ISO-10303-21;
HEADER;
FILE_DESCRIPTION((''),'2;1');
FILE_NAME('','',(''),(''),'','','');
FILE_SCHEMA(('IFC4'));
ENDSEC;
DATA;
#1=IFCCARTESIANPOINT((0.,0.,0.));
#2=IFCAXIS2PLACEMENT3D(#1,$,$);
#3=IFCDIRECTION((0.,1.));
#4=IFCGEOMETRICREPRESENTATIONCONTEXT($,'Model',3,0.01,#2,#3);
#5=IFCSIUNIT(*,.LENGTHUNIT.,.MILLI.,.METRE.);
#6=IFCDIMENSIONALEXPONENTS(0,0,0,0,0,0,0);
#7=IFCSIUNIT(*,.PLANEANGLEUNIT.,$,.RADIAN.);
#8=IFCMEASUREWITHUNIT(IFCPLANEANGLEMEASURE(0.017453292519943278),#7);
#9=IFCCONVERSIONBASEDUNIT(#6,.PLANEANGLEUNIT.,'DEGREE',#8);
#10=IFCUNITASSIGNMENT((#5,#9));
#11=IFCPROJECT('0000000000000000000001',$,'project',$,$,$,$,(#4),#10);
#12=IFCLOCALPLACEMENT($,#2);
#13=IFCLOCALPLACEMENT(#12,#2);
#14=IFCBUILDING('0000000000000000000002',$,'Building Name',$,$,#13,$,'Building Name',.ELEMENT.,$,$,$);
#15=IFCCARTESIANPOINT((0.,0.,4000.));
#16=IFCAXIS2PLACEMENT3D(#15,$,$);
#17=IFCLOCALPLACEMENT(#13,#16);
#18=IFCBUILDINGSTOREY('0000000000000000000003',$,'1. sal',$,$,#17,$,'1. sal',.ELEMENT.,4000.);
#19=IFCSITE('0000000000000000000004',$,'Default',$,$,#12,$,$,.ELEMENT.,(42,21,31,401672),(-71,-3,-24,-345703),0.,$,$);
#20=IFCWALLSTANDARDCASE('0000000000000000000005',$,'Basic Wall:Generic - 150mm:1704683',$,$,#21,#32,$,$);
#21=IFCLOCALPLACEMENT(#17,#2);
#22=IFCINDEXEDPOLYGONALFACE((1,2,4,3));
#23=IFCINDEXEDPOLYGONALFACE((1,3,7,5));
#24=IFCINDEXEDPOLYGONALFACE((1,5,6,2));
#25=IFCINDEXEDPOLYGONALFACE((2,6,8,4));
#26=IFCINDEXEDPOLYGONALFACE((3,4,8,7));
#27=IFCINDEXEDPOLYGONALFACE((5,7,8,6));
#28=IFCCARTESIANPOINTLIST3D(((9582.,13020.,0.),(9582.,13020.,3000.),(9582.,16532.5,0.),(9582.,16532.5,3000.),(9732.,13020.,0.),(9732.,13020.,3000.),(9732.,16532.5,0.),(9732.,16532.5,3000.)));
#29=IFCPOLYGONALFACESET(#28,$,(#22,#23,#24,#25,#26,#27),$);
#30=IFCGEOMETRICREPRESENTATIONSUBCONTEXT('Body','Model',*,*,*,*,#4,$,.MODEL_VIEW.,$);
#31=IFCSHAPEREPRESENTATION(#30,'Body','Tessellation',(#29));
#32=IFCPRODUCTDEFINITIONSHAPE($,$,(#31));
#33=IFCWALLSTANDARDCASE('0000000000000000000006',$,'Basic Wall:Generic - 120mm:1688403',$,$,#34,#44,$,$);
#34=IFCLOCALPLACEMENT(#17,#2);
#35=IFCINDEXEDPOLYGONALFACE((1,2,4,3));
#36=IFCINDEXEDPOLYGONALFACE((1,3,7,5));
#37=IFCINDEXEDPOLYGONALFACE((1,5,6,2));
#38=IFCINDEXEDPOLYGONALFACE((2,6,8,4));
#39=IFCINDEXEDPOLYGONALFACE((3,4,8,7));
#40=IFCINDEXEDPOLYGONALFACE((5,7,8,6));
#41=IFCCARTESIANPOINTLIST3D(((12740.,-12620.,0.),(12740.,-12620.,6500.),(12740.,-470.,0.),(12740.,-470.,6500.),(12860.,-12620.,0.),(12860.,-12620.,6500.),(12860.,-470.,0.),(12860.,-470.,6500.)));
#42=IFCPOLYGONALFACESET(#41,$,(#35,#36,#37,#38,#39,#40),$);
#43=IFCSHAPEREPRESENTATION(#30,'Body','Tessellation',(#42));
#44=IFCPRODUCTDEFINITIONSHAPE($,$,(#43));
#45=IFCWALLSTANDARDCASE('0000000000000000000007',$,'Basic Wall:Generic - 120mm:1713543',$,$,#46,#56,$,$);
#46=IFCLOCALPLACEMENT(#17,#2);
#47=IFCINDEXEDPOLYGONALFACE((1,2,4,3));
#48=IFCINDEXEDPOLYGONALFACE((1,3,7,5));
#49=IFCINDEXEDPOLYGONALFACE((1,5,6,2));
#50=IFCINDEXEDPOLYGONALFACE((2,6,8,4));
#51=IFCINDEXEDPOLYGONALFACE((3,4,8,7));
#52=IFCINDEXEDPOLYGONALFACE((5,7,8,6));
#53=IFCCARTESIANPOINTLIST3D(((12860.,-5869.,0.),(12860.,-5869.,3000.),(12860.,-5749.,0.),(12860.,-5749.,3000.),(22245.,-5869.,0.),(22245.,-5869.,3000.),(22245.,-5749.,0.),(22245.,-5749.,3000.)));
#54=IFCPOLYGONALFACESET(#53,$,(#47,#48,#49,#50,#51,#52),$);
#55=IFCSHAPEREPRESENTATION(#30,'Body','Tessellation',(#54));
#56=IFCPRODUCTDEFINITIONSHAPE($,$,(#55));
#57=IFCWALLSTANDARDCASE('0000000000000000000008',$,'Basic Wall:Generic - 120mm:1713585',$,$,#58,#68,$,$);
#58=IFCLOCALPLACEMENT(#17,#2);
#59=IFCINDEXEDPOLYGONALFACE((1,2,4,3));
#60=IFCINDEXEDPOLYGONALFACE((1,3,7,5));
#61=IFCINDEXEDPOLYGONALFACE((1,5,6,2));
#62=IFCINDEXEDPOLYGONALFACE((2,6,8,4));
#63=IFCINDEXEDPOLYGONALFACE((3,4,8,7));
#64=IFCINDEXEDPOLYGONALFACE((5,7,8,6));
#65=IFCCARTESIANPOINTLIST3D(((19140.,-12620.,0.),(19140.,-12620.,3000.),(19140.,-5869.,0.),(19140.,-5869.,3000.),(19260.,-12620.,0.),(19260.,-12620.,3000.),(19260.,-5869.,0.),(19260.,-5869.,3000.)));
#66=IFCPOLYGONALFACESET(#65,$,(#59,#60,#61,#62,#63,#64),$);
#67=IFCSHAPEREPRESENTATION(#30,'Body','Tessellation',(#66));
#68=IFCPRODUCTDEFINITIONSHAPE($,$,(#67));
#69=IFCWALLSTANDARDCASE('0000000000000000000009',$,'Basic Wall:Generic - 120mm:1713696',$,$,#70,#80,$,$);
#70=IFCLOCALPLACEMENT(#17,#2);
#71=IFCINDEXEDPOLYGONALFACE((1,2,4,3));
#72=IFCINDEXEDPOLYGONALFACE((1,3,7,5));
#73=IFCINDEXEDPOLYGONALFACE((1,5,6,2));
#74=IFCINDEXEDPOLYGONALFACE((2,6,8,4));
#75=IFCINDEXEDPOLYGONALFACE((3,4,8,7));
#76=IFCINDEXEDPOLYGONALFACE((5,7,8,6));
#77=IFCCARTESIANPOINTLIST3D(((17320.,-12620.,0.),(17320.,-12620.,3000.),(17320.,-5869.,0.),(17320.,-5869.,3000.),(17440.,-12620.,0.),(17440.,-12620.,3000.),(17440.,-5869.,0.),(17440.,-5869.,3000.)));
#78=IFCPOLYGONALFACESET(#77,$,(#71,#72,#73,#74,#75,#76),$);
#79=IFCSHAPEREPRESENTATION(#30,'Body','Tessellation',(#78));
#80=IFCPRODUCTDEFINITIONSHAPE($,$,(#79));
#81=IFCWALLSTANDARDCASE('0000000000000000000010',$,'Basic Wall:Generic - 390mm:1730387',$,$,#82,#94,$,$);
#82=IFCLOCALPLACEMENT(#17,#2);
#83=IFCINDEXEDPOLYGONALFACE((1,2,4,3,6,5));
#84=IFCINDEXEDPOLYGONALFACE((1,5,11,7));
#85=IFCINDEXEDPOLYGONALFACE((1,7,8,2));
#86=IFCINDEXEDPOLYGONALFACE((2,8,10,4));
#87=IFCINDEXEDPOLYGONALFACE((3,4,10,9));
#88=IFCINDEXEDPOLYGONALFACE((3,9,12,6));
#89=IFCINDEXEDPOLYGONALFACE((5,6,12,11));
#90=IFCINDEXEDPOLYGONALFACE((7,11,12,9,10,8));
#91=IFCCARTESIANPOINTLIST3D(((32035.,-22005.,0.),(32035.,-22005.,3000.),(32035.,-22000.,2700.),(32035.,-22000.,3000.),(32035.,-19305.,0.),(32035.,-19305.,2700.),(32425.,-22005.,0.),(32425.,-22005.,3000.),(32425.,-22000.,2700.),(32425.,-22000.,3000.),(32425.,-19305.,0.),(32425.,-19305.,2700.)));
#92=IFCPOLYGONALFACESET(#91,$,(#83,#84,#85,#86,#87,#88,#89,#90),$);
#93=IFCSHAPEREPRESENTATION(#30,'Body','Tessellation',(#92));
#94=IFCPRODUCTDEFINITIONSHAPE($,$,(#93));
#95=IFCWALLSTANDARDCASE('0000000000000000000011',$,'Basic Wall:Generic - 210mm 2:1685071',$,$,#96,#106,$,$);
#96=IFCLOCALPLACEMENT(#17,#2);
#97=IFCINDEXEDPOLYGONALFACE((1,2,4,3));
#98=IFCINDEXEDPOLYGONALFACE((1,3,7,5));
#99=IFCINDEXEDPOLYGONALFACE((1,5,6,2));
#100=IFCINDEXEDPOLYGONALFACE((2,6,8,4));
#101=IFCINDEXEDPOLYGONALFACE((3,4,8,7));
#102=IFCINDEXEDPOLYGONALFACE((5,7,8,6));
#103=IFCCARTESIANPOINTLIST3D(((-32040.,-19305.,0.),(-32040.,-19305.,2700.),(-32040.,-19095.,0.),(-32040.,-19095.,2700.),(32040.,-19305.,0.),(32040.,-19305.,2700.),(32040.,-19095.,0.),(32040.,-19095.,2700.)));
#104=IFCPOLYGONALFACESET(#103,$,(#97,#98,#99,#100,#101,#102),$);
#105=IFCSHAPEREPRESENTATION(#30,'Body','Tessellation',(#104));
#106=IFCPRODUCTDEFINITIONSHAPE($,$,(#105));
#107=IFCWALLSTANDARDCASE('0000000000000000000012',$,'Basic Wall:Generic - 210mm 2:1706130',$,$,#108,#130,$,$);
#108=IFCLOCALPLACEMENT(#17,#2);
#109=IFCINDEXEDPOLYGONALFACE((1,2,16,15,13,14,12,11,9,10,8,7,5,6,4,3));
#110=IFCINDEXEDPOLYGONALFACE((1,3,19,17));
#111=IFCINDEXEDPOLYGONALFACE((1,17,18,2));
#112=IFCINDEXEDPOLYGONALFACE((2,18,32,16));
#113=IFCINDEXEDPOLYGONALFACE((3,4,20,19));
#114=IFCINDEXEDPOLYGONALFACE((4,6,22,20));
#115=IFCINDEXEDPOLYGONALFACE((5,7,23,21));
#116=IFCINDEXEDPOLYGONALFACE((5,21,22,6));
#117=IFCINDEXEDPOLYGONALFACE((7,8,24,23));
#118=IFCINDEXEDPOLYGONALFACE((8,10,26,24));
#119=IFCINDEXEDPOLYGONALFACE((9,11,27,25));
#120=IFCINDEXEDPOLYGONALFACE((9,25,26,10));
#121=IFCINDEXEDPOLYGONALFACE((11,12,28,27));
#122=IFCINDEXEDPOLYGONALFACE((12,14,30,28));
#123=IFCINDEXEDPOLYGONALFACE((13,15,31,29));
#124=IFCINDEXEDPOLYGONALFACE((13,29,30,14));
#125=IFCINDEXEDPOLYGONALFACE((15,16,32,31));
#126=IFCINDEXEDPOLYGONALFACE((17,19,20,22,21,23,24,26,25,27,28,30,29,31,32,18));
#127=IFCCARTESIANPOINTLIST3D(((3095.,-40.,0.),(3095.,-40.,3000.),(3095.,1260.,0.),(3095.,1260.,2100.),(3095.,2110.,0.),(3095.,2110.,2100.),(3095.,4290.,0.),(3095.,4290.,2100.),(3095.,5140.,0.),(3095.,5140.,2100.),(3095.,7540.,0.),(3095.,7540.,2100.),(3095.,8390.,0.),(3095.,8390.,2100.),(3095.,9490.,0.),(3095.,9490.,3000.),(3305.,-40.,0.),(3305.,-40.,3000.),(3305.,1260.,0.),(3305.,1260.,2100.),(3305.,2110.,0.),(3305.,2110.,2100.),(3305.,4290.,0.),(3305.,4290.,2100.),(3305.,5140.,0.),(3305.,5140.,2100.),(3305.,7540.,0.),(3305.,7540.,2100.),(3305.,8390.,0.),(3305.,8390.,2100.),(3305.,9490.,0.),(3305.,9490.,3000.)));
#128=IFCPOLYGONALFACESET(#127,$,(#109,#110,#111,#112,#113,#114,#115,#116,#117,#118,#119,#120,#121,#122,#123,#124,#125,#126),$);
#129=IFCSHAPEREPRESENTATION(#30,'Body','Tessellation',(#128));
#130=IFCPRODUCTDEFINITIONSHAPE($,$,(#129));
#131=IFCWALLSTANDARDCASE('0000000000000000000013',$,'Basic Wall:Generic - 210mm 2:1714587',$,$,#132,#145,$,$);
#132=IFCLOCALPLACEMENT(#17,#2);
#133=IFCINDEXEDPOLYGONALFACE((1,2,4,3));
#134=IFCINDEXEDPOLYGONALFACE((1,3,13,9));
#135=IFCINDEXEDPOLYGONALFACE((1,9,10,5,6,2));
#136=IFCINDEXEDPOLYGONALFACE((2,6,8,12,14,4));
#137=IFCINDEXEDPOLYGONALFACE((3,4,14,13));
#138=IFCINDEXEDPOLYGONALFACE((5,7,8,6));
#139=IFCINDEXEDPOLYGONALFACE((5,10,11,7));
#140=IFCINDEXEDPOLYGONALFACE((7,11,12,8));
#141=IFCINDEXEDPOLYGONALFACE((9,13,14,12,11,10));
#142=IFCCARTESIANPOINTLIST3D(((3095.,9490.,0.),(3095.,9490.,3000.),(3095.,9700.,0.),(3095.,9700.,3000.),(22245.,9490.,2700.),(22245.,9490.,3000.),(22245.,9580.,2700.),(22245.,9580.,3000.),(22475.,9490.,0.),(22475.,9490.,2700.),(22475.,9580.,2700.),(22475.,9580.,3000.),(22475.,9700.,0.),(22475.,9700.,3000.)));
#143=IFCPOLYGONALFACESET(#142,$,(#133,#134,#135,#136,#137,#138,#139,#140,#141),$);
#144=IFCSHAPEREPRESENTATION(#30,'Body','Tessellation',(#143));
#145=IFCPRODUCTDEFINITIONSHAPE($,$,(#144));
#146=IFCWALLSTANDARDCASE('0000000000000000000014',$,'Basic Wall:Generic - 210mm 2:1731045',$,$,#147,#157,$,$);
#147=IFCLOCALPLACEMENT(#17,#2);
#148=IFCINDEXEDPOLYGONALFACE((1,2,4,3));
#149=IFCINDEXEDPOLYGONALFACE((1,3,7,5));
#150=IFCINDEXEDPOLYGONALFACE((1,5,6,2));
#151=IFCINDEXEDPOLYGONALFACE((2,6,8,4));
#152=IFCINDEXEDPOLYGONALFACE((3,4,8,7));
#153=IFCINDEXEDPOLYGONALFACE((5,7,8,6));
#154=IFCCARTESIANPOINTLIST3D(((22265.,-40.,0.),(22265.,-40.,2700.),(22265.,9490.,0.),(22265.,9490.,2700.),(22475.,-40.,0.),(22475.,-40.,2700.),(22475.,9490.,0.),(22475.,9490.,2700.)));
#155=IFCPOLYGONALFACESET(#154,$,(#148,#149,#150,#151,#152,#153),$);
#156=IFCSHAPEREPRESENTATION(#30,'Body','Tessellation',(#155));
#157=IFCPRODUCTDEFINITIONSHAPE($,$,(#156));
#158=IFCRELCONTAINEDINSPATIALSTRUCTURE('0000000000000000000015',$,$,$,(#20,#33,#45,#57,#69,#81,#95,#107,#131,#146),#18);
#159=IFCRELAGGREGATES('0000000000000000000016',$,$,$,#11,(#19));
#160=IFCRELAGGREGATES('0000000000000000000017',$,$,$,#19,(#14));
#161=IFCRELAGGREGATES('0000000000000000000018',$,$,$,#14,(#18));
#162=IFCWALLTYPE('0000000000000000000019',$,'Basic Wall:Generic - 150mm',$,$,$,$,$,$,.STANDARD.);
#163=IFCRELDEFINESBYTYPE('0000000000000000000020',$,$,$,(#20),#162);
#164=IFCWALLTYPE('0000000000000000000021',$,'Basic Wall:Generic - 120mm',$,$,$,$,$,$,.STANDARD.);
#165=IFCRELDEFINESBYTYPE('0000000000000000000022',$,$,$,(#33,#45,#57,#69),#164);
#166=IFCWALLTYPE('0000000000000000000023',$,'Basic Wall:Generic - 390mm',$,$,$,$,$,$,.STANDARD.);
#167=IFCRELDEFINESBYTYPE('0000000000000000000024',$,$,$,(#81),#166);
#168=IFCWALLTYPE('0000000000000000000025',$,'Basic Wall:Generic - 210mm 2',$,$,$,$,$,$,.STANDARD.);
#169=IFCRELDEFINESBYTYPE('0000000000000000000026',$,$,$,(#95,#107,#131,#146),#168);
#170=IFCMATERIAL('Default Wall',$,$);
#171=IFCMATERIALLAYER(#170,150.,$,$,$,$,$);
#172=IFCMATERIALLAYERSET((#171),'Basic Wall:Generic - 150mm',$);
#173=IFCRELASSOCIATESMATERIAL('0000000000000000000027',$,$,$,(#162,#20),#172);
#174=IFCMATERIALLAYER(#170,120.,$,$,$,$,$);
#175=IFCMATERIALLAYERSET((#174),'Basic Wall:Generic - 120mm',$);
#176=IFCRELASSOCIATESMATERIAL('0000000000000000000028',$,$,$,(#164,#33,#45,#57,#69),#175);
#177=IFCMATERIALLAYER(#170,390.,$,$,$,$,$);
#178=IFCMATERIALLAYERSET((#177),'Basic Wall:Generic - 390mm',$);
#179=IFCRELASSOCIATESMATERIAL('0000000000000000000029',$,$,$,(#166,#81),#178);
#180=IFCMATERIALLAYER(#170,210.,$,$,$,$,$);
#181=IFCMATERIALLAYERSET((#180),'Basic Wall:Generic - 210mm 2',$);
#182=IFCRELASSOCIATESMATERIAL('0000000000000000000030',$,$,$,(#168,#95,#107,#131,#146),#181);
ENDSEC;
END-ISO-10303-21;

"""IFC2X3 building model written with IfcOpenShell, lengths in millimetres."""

from ifc_helpers import new_model, entity, si_unit, converted_unit, direction, frame, frame_2d, origin, place, context, subcontext, project, spatial, polyline, rectangle, extrude, clip, bounded_halfspace, material, layer, layer_set, layer_usage, type_object, element, save


model = new_model("IFC2X3")

# Units and contexts
model_context = context("Model", 3, precision=0.01, world=origin(), true_north=direction((0.0, 1.0)))
body_context = subcontext(model_context, "Body", "Model", "MODEL_VIEW")
ifc_project = project(units=[si_unit("LENGTHUNIT", "METRE", prefix="MILLI"), converted_unit("PLANEANGLEUNIT", "DEGREE", entity("IfcPlaneAngleMeasure", 0.017453292519943278), si_unit("PLANEANGLEUNIT", "RADIAN"), dimensions=[0, 0, 0, 0, 0, 0, 0])], contexts=[model_context])

# Site, building, storey
site_placement = place(None, origin())
site = spatial("IfcSite", under=ifc_project, at=site_placement, Name="Default", CompositionType="ELEMENT", RefLatitude=(42, 21, 31, 401672), RefLongitude=(-71, -3, -24, -345703), RefElevation=0.0)
building_placement = place(site_placement, origin())
building = spatial("IfcBuilding", under=site, at=building_placement, Name="Building Name", LongName="Building Name", CompositionType="ELEMENT")
storey_placement = place(building_placement, frame((0.0, 0.0, 4000.0)))
storey = spatial("IfcBuildingStorey", under=building, at=storey_placement, Name="1. sal", LongName="1. sal", CompositionType="ELEMENT", Elevation=4000.0)

# Shared definitions
ifc_material_1 = material(Name="Default Wall")

# Walls
ifc_layer_1 = layer(ifc_material_1, 150.0)
ifc_layer_set_1 = layer_set([ifc_layer_1], Name="Basic Wall:Generic - 150mm")
wall_type_1 = type_object("IfcWallType", Name="Basic Wall:Generic - 150mm", PredefinedType="STANDARD", material=ifc_layer_set_1)
ifc_layer_usage_1 = layer_usage(ifc_layer_set_1, "AXIS2", "NEGATIVE", 75.0)
wall_1_placement = place(storey_placement, frame((9657.0, 16532.5, 0.0), z_axis=(0.0, 0.0, 1.0), x_axis=(0.0, -1.0, 0.0)))
element("IfcWallStandardCase", 1, at=wall_1_placement, inside=storey, type_object=wall_type_1, material=ifc_layer_usage_1, Name="Basic Wall:Generic - 150mm:1704683", context=body_context, shape_type="SweptSolid", body=[
    extrude(rectangle(XDim=3512.5, YDim=150.0, at=frame_2d((1756.2, 0.0), x_axis=(-1.0, 0.0))), origin(), (0.0, 0.0, 1.0), 3000.0),
])
ifc_layer_2 = layer(ifc_material_1, 120.0)
ifc_layer_set_2 = layer_set([ifc_layer_2], Name="Basic Wall:Generic - 120mm")
ifc_layer_usage_2 = layer_usage(ifc_layer_set_2, "AXIS2", "NEGATIVE", 60.0)
wall_type_2 = type_object("IfcWallType", Name="Basic Wall:Generic - 120mm", PredefinedType="STANDARD", material=ifc_layer_set_2)
wall_2_placement = place(storey_placement, frame((12800.0, -470.0, 0.0), z_axis=(0.0, 0.0, 1.0), x_axis=(0.0, -1.0, 0.0)))
element("IfcWallStandardCase", 2, at=wall_2_placement, inside=storey, type_object=wall_type_2, material=ifc_layer_usage_2, Name="Basic Wall:Generic - 120mm:1688403", context=body_context, shape_type="SweptSolid", body=[
    extrude(rectangle(XDim=12150.0, YDim=120.0, at=frame_2d((6075.0, 0.0), x_axis=(-1.0, 0.0))), origin(), (0.0, 0.0, 1.0), 6500.0),
])
ifc_layer_usage_3 = layer_usage(ifc_layer_set_2, "AXIS2", "NEGATIVE", 60.0)
wall_3_placement = place(storey_placement, frame((12860.0, -5809.0, 0.0)))
element("IfcWallStandardCase", 3, at=wall_3_placement, inside=storey, type_object=wall_type_2, material=ifc_layer_usage_3, Name="Basic Wall:Generic - 120mm:1713543", context=body_context, shape_type="SweptSolid", body=[
    extrude(rectangle(XDim=9385.0, YDim=120.0, at=frame_2d((4692.5, 0.0), x_axis=(-1.0, 0.0))), origin(), (0.0, 0.0, 1.0), 3000.0),
])
ifc_layer_usage_4 = layer_usage(ifc_layer_set_2, "AXIS2", "NEGATIVE", 60.0)
wall_4_placement = place(storey_placement, frame((19200.0, -5869.0, 0.0), z_axis=(0.0, 0.0, 1.0), x_axis=(0.0, -1.0, 0.0)))
element("IfcWallStandardCase", 4, at=wall_4_placement, inside=storey, type_object=wall_type_2, material=ifc_layer_usage_4, Name="Basic Wall:Generic - 120mm:1713585", context=body_context, shape_type="SweptSolid", body=[
    extrude(rectangle(XDim=6751.0, YDim=120.0, at=frame_2d((3375.5, 0.0), x_axis=(-1.0, 0.0))), origin(), (0.0, 0.0, 1.0), 3000.0),
])
ifc_layer_usage_5 = layer_usage(ifc_layer_set_2, "AXIS2", "NEGATIVE", 60.0)
wall_5_placement = place(storey_placement, frame((17380.0, -5869.0, 0.0), z_axis=(0.0, 0.0, 1.0), x_axis=(0.0, -1.0, 0.0)))
element("IfcWallStandardCase", 5, at=wall_5_placement, inside=storey, type_object=wall_type_2, material=ifc_layer_usage_5, Name="Basic Wall:Generic - 120mm:1713696", context=body_context, shape_type="SweptSolid", body=[
    extrude(rectangle(XDim=6751.0, YDim=120.0, at=frame_2d((3375.5, 0.0), x_axis=(-1.0, 0.0))), origin(), (0.0, 0.0, 1.0), 3000.0),
])
ifc_layer_3 = layer(ifc_material_1, 390.0)
ifc_layer_set_3 = layer_set([ifc_layer_3], Name="Basic Wall:Generic - 390mm")
ifc_layer_usage_6 = layer_usage(ifc_layer_set_3, "AXIS2", "NEGATIVE", 195.0)
wall_type_3 = type_object("IfcWallType", Name="Basic Wall:Generic - 390mm", PredefinedType="STANDARD", material=ifc_layer_set_3)
wall_6_placement = place(storey_placement, frame((32230.0, -19305.0, 0.0), z_axis=(0.0, 0.0, 1.0), x_axis=(0.0, -1.0, 0.0)))
element("IfcWallStandardCase", 6, at=wall_6_placement, inside=storey, type_object=wall_type_3, material=ifc_layer_usage_6, Name="Basic Wall:Generic - 390mm:1730387", context=body_context, shape_type="Clipping", body=[
    clip(extrude(rectangle(XDim=2700.0, YDim=390.0, at=frame_2d((1350.0, 0.0), x_axis=(-1.0, 0.0))), origin(), (0.0, 0.0, 1.0), 3000.0), bounded_halfspace(frame((0.0, -195.0, 2700.0), z_axis=(0.0, 0.0, -1.0), x_axis=(-1.0, 0.0, 0.0)), True, frame((0.0, -195.0, 2700.0)), polyline([(0.0, 0.0), (2695.0, 0.0), (2695.0, 390.0), (0.0, 390.0), (0.0, 5.0), (0.0, 0.0)]))),
])
ifc_layer_4 = layer(ifc_material_1, 210.0)
ifc_layer_set_4 = layer_set([ifc_layer_4], Name="Basic Wall:Generic - 210mm 2")
ifc_layer_usage_7 = layer_usage(ifc_layer_set_4, "AXIS2", "NEGATIVE", 105.0)
wall_type_4 = type_object("IfcWallType", Name="Basic Wall:Generic - 210mm 2", PredefinedType="STANDARD", material=ifc_layer_set_4)
wall_7_placement = place(storey_placement, frame((32040.0, -19200.0, 0.0), z_axis=(0.0, 0.0, 1.0), x_axis=(-1.0, 0.0, 0.0)))
element("IfcWallStandardCase", 7, at=wall_7_placement, inside=storey, type_object=wall_type_4, material=ifc_layer_usage_7, Name="Basic Wall:Generic - 210mm 2:1685071", context=body_context, shape_type="Clipping", body=[
    clip(extrude(rectangle(XDim=64080.0, YDim=210.0, at=frame_2d((32040.0, 0.0), x_axis=(-1.0, 0.0))), origin(), (0.0, 0.0, 1.0), 2700.0), bounded_halfspace(frame((0.0, -105.0, 2700.0), z_axis=(0.0, 0.0, -1.0), x_axis=(0.0, -1.0, 0.0)), True, frame((0.0, -105.0, 2700.0)), polyline([(0.0, 0.0), (64080.0, 0.0), (64080.0, 210.0), (5.0, 210.0), (0.0, 210.0), (0.0, 0.0)]))),
])

# Wall, openings
ifc_layer_usage_8 = layer_usage(ifc_layer_set_4, "AXIS2", "NEGATIVE", 105.0)
wall_8_placement = place(storey_placement, frame((3200.0, 9490.0, 0.0), z_axis=(0.0, 0.0, 1.0), x_axis=(0.0, -1.0, 0.0)))
wall_8 = element("IfcWallStandardCase", 8, at=wall_8_placement, inside=storey, type_object=wall_type_4, material=ifc_layer_usage_8, Name="Basic Wall:Generic - 210mm 2:1706130", context=body_context, shape_type="SweptSolid", body=[
    extrude(rectangle(XDim=9530.0, YDim=210.0, at=frame_2d((4765.0, 0.0), x_axis=(1.0, 0.0))), origin(), (0.0, 0.0, 1.0), 3000.0),
])
opening_1_placement = place(wall_8_placement, frame((1950.0, 105.0, 0.0)))
element("IfcOpeningElement", 9, at=opening_1_placement, cuts=wall_8, ObjectType="Opening", context=body_context, shape_type="SweptSolid", body=[
    extrude(rectangle(XDim=2100.0, YDim=850.0, at=frame_2d((1050.0, 425.0), x_axis=(1.0, 0.0))), frame((0.0, 0.0, 0.0), z_axis=(0.0, -1.0, 0.0), x_axis=(0.0, 0.0, 1.0)), (0.0, 0.0, 1.0), 210.0),
])
opening_2_placement = place(wall_8_placement, frame((5200.0, 105.0, 0.0)))
element("IfcOpeningElement", 10, at=opening_2_placement, cuts=wall_8, ObjectType="Opening", context=body_context, shape_type="SweptSolid", body=[
    extrude(rectangle(XDim=2100.0, YDim=850.0, at=frame_2d((1050.0, 425.0), x_axis=(1.0, 0.0))), frame((0.0, 0.0, 0.0), z_axis=(0.0, -1.0, 0.0), x_axis=(0.0, 0.0, 1.0)), (0.0, 0.0, 1.0), 210.0),
])
opening_3_placement = place(wall_8_placement, frame((8230.0, 105.0, 0.0)))
element("IfcOpeningElement", 11, at=opening_3_placement, cuts=wall_8, ObjectType="Opening", context=body_context, shape_type="SweptSolid", body=[
    extrude(rectangle(XDim=2100.0, YDim=850.0, at=frame_2d((1050.0, 425.0), x_axis=(1.0, 0.0))), frame((0.0, 0.0, 0.0), z_axis=(0.0, -1.0, 0.0), x_axis=(0.0, 0.0, 1.0)), (0.0, 0.0, 1.0), 210.0),
])

# Walls
ifc_layer_usage_9 = layer_usage(ifc_layer_set_4, "AXIS2", "NEGATIVE", 105.0)
wall_9_placement = place(storey_placement, frame((3095.0, 9595.0, 0.0)))
element("IfcWallStandardCase", 12, at=wall_9_placement, inside=storey, type_object=wall_type_4, material=ifc_layer_usage_9, Name="Basic Wall:Generic - 210mm 2:1714587", context=body_context, shape_type="Clipping", body=[
    clip(extrude(rectangle(XDim=19380.0, YDim=210.0, at=frame_2d((9690.0, 0.0), x_axis=(-1.0, 0.0))), origin(), (0.0, 0.0, 1.0), 3000.0), bounded_halfspace(frame((19150.0, -105.0, 2700.0), z_axis=(0.0, 0.0, -1.0), x_axis=(0.0, 1.0, 0.0)), True, frame((19150.0, -105.0, 2700.0)), polyline([(0.0, 0.0), (20.0, 0.0), (230.0, 0.0), (230.0, 90.0), (0.0, 90.0), (0.0, 0.0)]))),
])
ifc_layer_usage_10 = layer_usage(ifc_layer_set_4, "AXIS2", "NEGATIVE", 105.0)
wall_10_placement = place(storey_placement, frame((22370.0, 9490.0, 0.0), z_axis=(0.0, 0.0, 1.0), x_axis=(0.0, -1.0, 0.0)))
element("IfcWallStandardCase", 13, at=wall_10_placement, inside=storey, type_object=wall_type_4, material=ifc_layer_usage_10, Name="Basic Wall:Generic - 210mm 2:1731045", context=body_context, shape_type="Clipping", body=[
    clip(extrude(rectangle(XDim=9530.0, YDim=210.0, at=frame_2d((4765.0, 0.0), x_axis=(-1.0, 0.0))), origin(), (0.0, 0.0, 1.0), 2700.0), bounded_halfspace(frame((0.0, -105.0, 2700.0), z_axis=(0.0, 0.0, -1.0), x_axis=(-1.0, 0.0, 0.0)), True, frame((0.0, -105.0, 2700.0)), polyline([(0.0, 0.0), (9530.0, 0.0), (9530.0, 210.0), (0.0, 210.0), (0.0, 0.0)]))),
])

save(model, "model.ifc")
